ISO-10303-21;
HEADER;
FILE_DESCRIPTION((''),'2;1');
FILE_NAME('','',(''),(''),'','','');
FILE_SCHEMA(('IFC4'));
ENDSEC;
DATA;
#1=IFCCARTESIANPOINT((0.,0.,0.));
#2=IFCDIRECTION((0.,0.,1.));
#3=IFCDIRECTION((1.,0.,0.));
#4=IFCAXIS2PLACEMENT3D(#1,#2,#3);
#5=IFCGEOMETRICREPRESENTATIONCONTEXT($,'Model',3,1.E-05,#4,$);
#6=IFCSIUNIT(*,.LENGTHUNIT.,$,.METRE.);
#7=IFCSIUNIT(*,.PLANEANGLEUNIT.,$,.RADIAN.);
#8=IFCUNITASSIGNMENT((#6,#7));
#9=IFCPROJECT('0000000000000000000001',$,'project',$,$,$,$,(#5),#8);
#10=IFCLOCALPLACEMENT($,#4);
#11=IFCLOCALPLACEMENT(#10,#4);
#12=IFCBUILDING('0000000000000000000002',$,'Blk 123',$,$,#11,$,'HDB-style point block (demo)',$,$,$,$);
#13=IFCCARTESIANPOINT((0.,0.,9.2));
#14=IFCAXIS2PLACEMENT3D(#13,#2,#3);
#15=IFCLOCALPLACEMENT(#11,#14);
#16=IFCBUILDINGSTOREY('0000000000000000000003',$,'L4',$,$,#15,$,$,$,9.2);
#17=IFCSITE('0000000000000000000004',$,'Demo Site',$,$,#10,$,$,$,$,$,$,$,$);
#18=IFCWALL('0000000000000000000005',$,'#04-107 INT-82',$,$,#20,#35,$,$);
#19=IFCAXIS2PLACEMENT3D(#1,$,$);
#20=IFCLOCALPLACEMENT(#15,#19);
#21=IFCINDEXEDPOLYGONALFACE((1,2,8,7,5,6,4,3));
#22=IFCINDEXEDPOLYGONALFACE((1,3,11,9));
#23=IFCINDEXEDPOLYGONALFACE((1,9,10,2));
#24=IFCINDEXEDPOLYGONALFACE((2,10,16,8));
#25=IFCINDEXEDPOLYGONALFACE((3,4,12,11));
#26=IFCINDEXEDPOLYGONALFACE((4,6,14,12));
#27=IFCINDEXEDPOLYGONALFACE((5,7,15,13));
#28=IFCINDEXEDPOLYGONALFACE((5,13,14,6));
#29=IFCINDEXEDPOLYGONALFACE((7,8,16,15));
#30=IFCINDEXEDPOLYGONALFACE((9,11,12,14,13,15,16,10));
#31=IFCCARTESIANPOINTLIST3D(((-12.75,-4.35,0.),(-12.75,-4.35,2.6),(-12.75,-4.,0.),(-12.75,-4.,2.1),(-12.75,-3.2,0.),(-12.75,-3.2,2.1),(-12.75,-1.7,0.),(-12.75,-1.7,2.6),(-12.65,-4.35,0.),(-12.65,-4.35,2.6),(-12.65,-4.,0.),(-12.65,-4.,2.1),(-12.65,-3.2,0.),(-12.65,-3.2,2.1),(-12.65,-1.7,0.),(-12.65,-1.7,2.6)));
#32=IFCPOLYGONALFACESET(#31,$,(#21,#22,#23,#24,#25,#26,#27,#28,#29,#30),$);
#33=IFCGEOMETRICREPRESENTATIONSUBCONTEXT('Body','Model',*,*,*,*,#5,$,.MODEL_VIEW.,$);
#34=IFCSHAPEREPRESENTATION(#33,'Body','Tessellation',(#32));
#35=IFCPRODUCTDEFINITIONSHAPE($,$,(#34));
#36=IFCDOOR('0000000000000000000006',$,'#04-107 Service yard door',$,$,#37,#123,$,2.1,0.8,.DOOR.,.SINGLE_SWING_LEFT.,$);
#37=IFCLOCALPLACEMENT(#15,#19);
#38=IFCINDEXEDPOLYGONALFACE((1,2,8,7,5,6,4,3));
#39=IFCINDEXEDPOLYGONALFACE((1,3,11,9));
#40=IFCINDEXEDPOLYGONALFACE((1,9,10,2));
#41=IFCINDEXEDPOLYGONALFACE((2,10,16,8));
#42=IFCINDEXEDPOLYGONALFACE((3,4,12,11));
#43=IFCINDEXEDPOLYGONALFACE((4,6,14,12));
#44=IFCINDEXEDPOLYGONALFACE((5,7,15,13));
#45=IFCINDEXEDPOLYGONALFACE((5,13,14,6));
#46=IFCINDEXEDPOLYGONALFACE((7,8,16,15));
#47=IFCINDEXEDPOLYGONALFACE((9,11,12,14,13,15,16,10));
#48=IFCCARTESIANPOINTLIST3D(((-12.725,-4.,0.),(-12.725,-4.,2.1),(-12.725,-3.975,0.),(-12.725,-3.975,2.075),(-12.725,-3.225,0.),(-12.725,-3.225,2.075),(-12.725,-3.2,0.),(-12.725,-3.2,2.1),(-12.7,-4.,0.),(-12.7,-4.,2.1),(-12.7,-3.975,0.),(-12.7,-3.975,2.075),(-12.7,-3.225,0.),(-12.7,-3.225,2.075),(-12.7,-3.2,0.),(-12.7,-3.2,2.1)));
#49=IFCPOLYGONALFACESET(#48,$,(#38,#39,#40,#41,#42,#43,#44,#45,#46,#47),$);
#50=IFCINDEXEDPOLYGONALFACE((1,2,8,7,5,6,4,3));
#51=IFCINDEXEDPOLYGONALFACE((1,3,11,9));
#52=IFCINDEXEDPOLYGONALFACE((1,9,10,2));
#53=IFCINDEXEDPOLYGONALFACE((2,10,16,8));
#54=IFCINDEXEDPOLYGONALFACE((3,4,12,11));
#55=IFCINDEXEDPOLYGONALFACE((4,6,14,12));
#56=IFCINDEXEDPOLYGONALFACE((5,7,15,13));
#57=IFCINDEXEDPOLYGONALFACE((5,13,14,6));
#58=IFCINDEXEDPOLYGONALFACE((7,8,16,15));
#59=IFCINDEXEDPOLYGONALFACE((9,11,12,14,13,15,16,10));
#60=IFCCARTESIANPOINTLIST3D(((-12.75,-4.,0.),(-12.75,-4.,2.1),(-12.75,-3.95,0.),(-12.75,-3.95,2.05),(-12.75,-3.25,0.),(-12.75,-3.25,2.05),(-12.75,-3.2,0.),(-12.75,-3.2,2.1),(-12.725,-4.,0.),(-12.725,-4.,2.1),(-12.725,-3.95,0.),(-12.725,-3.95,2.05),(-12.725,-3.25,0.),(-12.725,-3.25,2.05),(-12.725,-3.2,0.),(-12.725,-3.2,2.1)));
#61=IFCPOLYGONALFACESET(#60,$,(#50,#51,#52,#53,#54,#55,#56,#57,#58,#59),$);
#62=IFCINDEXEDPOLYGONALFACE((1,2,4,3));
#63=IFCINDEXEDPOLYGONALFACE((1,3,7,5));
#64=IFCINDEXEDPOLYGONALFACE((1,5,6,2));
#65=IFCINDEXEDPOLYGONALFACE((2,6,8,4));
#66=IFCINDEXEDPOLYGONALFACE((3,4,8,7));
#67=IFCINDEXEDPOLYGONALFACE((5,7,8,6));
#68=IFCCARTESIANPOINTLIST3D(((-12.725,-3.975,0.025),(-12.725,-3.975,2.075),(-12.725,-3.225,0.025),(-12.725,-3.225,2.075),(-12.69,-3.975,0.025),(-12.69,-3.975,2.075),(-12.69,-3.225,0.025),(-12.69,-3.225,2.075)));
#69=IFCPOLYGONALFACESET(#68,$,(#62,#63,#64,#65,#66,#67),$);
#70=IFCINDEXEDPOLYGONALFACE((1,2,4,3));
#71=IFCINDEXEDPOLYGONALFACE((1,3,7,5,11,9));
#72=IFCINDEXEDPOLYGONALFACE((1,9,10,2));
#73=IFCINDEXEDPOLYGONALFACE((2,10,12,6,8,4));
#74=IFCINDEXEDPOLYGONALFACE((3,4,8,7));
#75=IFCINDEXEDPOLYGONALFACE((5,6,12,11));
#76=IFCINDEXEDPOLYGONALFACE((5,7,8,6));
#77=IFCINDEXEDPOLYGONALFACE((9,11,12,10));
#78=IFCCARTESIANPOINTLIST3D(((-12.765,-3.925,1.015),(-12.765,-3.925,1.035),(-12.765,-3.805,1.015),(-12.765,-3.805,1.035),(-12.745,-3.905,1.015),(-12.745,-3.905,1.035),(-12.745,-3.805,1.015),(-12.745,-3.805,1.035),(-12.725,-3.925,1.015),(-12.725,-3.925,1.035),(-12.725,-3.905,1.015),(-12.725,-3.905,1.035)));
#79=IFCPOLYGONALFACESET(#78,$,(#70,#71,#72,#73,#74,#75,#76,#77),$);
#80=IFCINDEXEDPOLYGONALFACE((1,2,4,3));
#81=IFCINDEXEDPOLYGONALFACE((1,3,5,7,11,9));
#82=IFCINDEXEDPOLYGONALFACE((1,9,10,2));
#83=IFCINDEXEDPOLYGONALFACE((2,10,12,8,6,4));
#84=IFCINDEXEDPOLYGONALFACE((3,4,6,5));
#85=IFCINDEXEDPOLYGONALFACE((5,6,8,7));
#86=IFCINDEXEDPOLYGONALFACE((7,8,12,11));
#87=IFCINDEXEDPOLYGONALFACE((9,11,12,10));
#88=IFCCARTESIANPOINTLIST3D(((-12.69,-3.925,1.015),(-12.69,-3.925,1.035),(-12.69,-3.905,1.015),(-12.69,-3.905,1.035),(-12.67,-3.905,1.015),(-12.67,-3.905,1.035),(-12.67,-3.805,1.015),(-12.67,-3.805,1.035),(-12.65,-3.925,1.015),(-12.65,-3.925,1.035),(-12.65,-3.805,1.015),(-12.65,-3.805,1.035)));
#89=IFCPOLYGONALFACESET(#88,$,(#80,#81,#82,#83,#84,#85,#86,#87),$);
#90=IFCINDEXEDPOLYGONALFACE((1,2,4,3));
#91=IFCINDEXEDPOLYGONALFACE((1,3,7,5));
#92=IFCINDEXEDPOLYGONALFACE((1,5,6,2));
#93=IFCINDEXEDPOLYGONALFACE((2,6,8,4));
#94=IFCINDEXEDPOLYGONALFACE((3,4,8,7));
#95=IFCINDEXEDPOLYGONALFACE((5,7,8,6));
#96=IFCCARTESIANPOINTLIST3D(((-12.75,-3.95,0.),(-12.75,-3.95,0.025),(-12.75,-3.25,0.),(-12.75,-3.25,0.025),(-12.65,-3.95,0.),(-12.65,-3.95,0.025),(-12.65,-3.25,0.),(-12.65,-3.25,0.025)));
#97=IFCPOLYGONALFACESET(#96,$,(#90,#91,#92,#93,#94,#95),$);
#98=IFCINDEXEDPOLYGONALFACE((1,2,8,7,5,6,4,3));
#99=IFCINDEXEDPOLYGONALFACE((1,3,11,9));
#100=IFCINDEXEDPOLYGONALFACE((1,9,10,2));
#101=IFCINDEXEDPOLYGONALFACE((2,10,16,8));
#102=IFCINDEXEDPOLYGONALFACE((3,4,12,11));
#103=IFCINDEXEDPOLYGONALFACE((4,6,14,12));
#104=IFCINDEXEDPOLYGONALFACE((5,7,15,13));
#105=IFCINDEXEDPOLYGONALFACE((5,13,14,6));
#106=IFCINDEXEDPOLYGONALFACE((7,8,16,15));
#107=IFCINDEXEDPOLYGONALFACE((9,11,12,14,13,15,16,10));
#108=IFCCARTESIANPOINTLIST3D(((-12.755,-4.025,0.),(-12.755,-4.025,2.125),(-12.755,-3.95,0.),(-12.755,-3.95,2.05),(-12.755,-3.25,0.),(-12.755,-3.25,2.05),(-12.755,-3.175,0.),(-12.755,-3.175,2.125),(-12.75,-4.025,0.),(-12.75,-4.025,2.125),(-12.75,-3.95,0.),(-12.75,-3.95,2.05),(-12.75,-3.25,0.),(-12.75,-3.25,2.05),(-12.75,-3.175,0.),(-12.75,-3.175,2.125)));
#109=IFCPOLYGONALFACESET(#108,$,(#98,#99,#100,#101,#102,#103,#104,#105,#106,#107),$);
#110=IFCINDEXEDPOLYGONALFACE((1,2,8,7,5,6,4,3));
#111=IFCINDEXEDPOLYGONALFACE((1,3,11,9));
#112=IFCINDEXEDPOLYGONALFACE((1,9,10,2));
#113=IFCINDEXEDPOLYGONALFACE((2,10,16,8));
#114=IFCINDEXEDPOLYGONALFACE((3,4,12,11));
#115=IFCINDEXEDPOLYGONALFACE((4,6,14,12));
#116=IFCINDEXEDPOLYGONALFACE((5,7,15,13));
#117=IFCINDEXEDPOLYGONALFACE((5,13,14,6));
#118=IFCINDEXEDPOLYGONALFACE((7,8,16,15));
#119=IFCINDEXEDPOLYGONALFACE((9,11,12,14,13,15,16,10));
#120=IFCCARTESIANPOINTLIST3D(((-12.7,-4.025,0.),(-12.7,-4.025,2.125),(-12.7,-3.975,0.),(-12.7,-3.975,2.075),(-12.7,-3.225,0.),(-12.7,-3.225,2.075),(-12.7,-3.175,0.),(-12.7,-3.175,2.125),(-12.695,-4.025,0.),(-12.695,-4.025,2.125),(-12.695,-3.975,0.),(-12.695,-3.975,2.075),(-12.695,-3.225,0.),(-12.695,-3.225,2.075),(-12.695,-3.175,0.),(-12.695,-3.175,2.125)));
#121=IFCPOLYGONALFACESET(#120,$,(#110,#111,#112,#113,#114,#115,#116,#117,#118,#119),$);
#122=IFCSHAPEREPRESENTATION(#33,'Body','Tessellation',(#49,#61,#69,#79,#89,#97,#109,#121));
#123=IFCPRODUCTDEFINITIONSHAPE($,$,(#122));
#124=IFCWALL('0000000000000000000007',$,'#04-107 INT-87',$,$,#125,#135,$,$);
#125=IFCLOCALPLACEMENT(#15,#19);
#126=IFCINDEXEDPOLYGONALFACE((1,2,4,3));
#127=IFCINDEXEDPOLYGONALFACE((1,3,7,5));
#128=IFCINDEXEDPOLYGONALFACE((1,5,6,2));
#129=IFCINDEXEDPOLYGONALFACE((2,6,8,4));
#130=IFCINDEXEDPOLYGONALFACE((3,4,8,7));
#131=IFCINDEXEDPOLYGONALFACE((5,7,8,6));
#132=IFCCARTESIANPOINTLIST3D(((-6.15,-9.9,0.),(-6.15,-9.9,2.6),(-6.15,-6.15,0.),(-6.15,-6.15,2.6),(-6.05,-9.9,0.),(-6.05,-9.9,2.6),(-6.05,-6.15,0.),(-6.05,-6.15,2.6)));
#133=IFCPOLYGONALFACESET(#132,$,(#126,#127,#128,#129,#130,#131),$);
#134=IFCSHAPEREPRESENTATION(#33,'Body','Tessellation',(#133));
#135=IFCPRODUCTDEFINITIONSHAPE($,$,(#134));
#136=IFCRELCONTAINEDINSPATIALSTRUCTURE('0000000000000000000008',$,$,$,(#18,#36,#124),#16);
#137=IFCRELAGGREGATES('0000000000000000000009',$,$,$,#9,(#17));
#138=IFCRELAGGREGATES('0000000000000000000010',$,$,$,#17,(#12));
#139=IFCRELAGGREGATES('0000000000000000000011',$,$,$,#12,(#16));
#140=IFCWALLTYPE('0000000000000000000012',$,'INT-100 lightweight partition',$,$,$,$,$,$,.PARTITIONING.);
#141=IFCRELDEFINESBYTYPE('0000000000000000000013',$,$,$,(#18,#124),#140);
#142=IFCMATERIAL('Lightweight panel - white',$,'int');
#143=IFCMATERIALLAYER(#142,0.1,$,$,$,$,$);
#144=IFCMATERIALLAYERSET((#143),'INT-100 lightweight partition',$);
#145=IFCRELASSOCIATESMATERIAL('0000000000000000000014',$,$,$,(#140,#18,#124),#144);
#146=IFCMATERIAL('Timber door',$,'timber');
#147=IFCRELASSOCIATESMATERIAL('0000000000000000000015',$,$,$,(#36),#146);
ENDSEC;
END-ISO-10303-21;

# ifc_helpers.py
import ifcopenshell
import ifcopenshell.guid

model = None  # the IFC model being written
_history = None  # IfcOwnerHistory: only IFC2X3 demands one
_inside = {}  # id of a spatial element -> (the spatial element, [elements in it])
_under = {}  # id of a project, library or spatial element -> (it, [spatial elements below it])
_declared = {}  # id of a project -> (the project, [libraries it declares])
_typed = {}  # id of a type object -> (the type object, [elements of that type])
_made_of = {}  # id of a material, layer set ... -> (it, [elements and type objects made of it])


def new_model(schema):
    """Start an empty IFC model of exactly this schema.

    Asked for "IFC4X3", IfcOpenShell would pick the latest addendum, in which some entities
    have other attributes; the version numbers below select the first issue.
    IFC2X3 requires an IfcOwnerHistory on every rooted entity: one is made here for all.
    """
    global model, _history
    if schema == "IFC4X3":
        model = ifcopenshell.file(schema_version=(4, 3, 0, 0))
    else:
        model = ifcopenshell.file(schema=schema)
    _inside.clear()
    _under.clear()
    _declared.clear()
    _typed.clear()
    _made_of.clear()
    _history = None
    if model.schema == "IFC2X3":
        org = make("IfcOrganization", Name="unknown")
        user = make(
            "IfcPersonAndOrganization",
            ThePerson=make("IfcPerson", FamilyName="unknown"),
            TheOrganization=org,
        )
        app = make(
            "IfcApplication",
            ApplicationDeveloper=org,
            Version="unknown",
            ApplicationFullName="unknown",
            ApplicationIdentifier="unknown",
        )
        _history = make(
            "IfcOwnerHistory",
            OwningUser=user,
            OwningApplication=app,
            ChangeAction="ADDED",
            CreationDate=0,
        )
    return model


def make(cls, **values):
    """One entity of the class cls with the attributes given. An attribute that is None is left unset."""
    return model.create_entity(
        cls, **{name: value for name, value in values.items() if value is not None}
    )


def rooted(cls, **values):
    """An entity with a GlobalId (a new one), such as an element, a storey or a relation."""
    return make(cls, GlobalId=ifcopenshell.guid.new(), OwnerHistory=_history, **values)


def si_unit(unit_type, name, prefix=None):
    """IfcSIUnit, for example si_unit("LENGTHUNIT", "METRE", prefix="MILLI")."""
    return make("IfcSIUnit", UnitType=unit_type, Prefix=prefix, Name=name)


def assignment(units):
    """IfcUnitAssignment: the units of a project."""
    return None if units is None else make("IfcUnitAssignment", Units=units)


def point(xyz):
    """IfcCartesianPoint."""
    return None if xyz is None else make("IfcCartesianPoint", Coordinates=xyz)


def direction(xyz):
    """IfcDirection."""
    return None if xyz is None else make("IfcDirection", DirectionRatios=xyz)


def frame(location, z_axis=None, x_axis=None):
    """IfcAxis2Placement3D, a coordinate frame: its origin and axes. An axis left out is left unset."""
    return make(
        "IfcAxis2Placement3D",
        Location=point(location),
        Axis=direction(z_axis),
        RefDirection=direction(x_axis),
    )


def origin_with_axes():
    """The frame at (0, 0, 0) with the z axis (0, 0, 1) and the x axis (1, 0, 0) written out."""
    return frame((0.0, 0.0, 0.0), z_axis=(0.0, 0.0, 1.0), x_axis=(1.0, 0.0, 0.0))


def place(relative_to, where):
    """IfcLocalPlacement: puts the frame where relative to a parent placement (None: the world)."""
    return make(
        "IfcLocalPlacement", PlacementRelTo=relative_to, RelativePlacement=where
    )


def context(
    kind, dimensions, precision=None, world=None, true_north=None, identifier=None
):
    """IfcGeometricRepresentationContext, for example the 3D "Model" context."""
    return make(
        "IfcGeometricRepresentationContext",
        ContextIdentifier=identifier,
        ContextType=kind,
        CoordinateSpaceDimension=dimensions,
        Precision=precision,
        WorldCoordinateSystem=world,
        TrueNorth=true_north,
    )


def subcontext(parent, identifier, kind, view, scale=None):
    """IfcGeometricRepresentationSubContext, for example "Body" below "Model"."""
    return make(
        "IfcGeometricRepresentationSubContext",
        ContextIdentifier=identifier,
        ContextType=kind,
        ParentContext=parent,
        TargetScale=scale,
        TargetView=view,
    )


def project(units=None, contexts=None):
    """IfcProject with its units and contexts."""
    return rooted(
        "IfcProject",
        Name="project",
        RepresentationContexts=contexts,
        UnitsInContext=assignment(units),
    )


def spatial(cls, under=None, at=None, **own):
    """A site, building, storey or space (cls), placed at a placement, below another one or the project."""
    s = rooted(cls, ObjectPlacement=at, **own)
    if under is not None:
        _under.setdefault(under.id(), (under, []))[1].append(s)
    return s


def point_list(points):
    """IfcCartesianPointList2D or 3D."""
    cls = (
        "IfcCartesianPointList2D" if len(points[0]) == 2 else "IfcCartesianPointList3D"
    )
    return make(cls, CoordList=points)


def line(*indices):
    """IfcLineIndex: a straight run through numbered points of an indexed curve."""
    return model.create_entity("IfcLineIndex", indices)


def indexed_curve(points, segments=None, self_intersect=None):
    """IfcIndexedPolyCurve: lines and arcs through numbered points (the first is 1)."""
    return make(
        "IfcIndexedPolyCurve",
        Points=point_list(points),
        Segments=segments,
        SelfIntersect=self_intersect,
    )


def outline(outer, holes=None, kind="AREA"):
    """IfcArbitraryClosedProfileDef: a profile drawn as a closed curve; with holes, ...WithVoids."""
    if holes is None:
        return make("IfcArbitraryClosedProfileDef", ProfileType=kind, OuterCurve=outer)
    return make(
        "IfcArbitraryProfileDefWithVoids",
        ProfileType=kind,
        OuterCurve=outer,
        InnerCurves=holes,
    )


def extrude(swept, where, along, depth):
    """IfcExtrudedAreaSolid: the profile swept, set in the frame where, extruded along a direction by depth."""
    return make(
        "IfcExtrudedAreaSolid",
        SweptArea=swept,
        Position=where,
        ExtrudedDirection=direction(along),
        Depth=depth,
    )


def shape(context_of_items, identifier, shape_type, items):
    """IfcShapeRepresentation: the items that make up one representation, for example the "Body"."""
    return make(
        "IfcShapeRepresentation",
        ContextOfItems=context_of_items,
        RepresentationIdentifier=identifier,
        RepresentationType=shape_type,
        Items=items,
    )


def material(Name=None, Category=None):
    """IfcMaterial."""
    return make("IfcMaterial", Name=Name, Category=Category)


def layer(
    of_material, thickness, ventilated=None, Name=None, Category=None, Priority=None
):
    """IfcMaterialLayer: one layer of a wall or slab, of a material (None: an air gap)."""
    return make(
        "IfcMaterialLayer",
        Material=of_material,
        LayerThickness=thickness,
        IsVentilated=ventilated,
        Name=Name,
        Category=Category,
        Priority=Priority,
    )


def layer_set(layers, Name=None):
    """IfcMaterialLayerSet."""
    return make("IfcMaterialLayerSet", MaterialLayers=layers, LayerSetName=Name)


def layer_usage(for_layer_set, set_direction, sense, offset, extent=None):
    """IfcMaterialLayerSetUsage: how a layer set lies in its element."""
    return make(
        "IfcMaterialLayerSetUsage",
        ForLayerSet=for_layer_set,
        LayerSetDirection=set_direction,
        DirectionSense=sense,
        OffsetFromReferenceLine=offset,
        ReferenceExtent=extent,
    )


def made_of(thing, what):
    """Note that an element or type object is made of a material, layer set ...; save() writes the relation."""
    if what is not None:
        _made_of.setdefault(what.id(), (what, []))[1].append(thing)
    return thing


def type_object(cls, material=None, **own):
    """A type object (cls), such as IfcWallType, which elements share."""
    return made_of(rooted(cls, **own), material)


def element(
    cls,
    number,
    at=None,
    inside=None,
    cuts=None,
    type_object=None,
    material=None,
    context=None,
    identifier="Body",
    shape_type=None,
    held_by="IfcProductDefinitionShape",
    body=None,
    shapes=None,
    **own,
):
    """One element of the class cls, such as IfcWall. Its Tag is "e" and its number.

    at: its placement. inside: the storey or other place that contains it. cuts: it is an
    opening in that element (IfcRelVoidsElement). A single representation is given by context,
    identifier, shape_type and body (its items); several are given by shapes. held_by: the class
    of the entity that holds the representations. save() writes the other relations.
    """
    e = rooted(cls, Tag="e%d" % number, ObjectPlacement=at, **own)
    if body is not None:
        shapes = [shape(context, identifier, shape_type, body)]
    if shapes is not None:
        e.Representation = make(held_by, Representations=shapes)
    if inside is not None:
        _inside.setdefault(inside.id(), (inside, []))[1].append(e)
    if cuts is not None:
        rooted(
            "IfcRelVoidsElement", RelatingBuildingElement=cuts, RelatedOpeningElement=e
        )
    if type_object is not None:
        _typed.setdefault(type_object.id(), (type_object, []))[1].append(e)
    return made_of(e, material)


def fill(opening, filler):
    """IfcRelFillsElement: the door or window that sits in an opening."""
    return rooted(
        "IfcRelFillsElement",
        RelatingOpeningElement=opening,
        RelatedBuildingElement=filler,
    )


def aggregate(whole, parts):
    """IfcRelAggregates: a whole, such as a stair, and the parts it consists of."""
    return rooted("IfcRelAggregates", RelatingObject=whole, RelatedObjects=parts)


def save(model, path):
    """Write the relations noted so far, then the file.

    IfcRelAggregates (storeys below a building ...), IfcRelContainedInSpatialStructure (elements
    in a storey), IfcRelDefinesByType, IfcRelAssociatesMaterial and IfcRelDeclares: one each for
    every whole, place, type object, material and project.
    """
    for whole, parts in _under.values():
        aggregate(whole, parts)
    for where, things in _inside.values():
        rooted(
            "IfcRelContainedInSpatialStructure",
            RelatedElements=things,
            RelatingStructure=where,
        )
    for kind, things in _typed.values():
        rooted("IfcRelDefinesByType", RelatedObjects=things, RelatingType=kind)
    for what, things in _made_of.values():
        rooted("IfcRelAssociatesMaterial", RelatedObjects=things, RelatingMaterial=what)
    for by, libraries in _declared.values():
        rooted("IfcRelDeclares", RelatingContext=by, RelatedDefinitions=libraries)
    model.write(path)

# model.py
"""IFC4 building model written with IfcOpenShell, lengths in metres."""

from ifc_helpers import new_model, si_unit, frame, origin_with_axes, place, context, subcontext, project, spatial, line, indexed_curve, outline, extrude, material, layer, layer_set, layer_usage, type_object, element, fill, save


model = new_model("IFC4")

# Units and contexts
model_context = context("Model", 3, precision=1e-05, world=origin_with_axes())
body_context = subcontext(model_context, "Body", "Model", "MODEL_VIEW")
ifc_project = project(units=[si_unit("LENGTHUNIT", "METRE"), si_unit("PLANEANGLEUNIT", "RADIAN")], contexts=[model_context])

# Site, building, storey
site_placement = place(None, origin_with_axes())
site = spatial("IfcSite", under=ifc_project, at=site_placement, Name="Demo Site")
building_placement = place(site_placement, origin_with_axes())
building = spatial("IfcBuilding", under=site, at=building_placement, Name="Blk 123", LongName="HDB-style point block (demo)")
storey_placement = place(building_placement, frame((0.0, 0.0, 9.2), z_axis=(0.0, 0.0, 1.0), x_axis=(1.0, 0.0, 0.0)))
storey = spatial("IfcBuildingStorey", under=building, at=storey_placement, Name="L4", Elevation=9.2)

# Shared definitions
ifc_material_1 = material(Name="Lightweight panel - white", Category="int")
ifc_layer_1 = layer(ifc_material_1, 0.1)
ifc_layer_set_1 = layer_set([ifc_layer_1], Name="INT-100 lightweight partition")
ifc_layer_usage_1 = layer_usage(ifc_layer_set_1, "AXIS2", "POSITIVE", -0.05)
wall_type_1 = type_object("IfcWallType", Name="INT-100 lightweight partition", PredefinedType="PARTITIONING", material=ifc_layer_set_1)

# Wall, opening, door
ifc_material_2 = material(Name="Timber door", Category="timber")
wall_1_placement = place(storey_placement, frame((-12.7, -1.7, 0.0), z_axis=(0.0, 0.0, 1.0), x_axis=(0.0, -1.0, 0.0)))
wall_1 = element("IfcWall", 1, at=wall_1_placement, inside=storey, type_object=wall_type_1, material=ifc_layer_usage_1, Name="#04-107 INT-82", context=body_context, shape_type="SweptSolid", body=[
    extrude(outline(indexed_curve([(0.0, 0.0), (0.0, 0.1), (2.65, 0.1), (2.65, 0.0), (0.0, 0.0)], self_intersect=False)), frame((0.0, -0.05, 0.0), z_axis=(0.0, 0.0, 1.0), x_axis=(1.0, 0.0, 0.0)), (0.0, 0.0, 1.0), 2.6),
])
opening_1_placement = place(wall_1_placement, frame((1.5, -0.15, 0.0), z_axis=(0.0, 0.0, 1.0), x_axis=(1.0, 0.0, 0.0)))
opening_1 = element("IfcOpeningElement", 2, at=opening_1_placement, cuts=wall_1, context=body_context, shape_type="SweptSolid", body=[
    extrude(outline(indexed_curve([(0.0, 0.0), (0.0, 0.3), (0.8, 0.3), (0.8, 0.0), (0.0, 0.0)], self_intersect=False)), origin_with_axes(), (0.0, 0.0, 1.0), 2.1),
])
door_1_placement = place(opening_1_placement, frame((0.0, 0.1, 0.0), z_axis=(0.0, 0.0, 1.0), x_axis=(1.0, 0.0, 0.0)))
door_1 = element("IfcDoor", 3, at=door_1_placement, inside=storey, material=ifc_material_2, Name="#04-107 Service yard door", OperationType="SINGLE_SWING_LEFT", OverallHeight=2.1, OverallWidth=0.8, PredefinedType="DOOR", context=body_context, shape_type="SweptSolid", body=[
    extrude(outline(indexed_curve([(0.0, 0.0), (0.0, 2.1), (0.8, 2.1), (0.8, 0.0), (0.775, 0.0), (0.775, 2.075), (0.025, 2.075), (0.025, 0.0)], segments=[line(1, 2, 3, 4, 5, 6, 7, 8, 1)])), frame((0.0, 0.025, 0.0), z_axis=(0.0, -1.0, 0.0), x_axis=(1.0, 0.0, 0.0)), (0.0, 0.0, -1.0), 0.025),
    extrude(outline(indexed_curve([(0.0, 0.0), (0.0, 2.1), (0.8, 2.1), (0.8, 0.0), (0.75, 0.0), (0.75, 2.05), (0.05, 2.05), (0.05, 0.0)], segments=[line(1, 2, 3, 4, 5, 6, 7, 8, 1)])), frame((0.0, 0.0, 0.0), z_axis=(0.0, -1.0, 0.0), x_axis=(1.0, 0.0, 0.0)), (0.0, 0.0, -1.0), 0.025),
    extrude(outline(indexed_curve([(0.0, 0.0), (0.75, 0.0), (0.75, 0.035), (0.0, 0.035)], segments=[line(1, 2, 3, 4, 1)])), frame((0.025, 0.025, 0.025), z_axis=(0.0, 0.0, 1.0), x_axis=(1.0, 0.0, 0.0)), (0.0, 0.0, 1.0), 2.05),
    extrude(outline(indexed_curve([(0.0, 0.0), (0.0, -0.04), (-0.12, -0.04), (-0.12, -0.02), (-0.02, -0.02), (-0.02, 0.0)], segments=[line(1, 2, 3, 4, 5, 6, 1)])), frame((0.725, 0.025, 1.015), z_axis=(0.0, 0.0, 1.0), x_axis=(1.0, 0.0, 0.0)), (0.0, 0.0, 1.0), 0.02),
    extrude(outline(indexed_curve([(0.0, 0.0), (0.0, 0.04), (-0.12, 0.04), (-0.12, 0.02), (-0.02, 0.02), (-0.02, 0.0)], segments=[line(1, 2, 3, 4, 5, 6, 1)])), frame((0.725, 0.06, 1.015), z_axis=(0.0, 0.0, 1.0), x_axis=(1.0, 0.0, 0.0)), (0.0, 0.0, 1.0), 0.02),
    extrude(outline(indexed_curve([(0.0, 0.0), (0.7, 0.0), (0.7, 0.1), (0.0, 0.1)], segments=[line(1, 2, 3, 4, 1)])), frame((0.05, 0.0, 0.0), z_axis=(0.0, 0.0, 1.0), x_axis=(1.0, 0.0, 0.0)), (0.0, 0.0, 1.0), 0.025),
    extrude(outline(indexed_curve([(0.0, 0.0), (0.0, 2.125), (0.85, 2.125), (0.85, 0.0), (0.775, 0.0), (0.775, 2.05), (0.075, 2.05), (0.075, 0.0)], segments=[line(1, 2, 3, 4, 5, 6, 7, 8, 1)])), frame((-0.025, -0.005, 0.0), z_axis=(0.0, -1.0, 0.0), x_axis=(1.0, 0.0, 0.0)), (0.0, 0.0, -1.0), 0.005),
    extrude(outline(indexed_curve([(0.0, 0.0), (0.0, 2.125), (0.85, 2.125), (0.85, 0.0), (0.8, 0.0), (0.8, 2.075), (0.05, 2.075), (0.05, 0.0)], segments=[line(1, 2, 3, 4, 5, 6, 7, 8, 1)])), frame((-0.025, 0.05, 0.0), z_axis=(0.0, -1.0, 0.0), x_axis=(1.0, 0.0, 0.0)), (0.0, 0.0, -1.0), 0.005),
])
fill(opening_1, door_1)

# Wall
wall_2_placement = place(storey_placement, frame((-6.1, -6.15, 0.0), z_axis=(0.0, 0.0, 1.0), x_axis=(0.0, -1.0, 0.0)))
element("IfcWall", 4, at=wall_2_placement, inside=storey, type_object=wall_type_1, material=ifc_layer_usage_1, Name="#04-107 INT-87", context=body_context, shape_type="SweptSolid", body=[
    extrude(outline(indexed_curve([(0.0, 0.0), (0.0, 0.1), (3.75, 0.1), (3.75, 0.0), (0.0, 0.0)], self_intersect=False)), frame((0.0, -0.05, 0.0), z_axis=(0.0, 0.0, 1.0), x_axis=(1.0, 0.0, 0.0)), (0.0, 0.0, 1.0), 2.6),
])

save(model, "model.ifc")
